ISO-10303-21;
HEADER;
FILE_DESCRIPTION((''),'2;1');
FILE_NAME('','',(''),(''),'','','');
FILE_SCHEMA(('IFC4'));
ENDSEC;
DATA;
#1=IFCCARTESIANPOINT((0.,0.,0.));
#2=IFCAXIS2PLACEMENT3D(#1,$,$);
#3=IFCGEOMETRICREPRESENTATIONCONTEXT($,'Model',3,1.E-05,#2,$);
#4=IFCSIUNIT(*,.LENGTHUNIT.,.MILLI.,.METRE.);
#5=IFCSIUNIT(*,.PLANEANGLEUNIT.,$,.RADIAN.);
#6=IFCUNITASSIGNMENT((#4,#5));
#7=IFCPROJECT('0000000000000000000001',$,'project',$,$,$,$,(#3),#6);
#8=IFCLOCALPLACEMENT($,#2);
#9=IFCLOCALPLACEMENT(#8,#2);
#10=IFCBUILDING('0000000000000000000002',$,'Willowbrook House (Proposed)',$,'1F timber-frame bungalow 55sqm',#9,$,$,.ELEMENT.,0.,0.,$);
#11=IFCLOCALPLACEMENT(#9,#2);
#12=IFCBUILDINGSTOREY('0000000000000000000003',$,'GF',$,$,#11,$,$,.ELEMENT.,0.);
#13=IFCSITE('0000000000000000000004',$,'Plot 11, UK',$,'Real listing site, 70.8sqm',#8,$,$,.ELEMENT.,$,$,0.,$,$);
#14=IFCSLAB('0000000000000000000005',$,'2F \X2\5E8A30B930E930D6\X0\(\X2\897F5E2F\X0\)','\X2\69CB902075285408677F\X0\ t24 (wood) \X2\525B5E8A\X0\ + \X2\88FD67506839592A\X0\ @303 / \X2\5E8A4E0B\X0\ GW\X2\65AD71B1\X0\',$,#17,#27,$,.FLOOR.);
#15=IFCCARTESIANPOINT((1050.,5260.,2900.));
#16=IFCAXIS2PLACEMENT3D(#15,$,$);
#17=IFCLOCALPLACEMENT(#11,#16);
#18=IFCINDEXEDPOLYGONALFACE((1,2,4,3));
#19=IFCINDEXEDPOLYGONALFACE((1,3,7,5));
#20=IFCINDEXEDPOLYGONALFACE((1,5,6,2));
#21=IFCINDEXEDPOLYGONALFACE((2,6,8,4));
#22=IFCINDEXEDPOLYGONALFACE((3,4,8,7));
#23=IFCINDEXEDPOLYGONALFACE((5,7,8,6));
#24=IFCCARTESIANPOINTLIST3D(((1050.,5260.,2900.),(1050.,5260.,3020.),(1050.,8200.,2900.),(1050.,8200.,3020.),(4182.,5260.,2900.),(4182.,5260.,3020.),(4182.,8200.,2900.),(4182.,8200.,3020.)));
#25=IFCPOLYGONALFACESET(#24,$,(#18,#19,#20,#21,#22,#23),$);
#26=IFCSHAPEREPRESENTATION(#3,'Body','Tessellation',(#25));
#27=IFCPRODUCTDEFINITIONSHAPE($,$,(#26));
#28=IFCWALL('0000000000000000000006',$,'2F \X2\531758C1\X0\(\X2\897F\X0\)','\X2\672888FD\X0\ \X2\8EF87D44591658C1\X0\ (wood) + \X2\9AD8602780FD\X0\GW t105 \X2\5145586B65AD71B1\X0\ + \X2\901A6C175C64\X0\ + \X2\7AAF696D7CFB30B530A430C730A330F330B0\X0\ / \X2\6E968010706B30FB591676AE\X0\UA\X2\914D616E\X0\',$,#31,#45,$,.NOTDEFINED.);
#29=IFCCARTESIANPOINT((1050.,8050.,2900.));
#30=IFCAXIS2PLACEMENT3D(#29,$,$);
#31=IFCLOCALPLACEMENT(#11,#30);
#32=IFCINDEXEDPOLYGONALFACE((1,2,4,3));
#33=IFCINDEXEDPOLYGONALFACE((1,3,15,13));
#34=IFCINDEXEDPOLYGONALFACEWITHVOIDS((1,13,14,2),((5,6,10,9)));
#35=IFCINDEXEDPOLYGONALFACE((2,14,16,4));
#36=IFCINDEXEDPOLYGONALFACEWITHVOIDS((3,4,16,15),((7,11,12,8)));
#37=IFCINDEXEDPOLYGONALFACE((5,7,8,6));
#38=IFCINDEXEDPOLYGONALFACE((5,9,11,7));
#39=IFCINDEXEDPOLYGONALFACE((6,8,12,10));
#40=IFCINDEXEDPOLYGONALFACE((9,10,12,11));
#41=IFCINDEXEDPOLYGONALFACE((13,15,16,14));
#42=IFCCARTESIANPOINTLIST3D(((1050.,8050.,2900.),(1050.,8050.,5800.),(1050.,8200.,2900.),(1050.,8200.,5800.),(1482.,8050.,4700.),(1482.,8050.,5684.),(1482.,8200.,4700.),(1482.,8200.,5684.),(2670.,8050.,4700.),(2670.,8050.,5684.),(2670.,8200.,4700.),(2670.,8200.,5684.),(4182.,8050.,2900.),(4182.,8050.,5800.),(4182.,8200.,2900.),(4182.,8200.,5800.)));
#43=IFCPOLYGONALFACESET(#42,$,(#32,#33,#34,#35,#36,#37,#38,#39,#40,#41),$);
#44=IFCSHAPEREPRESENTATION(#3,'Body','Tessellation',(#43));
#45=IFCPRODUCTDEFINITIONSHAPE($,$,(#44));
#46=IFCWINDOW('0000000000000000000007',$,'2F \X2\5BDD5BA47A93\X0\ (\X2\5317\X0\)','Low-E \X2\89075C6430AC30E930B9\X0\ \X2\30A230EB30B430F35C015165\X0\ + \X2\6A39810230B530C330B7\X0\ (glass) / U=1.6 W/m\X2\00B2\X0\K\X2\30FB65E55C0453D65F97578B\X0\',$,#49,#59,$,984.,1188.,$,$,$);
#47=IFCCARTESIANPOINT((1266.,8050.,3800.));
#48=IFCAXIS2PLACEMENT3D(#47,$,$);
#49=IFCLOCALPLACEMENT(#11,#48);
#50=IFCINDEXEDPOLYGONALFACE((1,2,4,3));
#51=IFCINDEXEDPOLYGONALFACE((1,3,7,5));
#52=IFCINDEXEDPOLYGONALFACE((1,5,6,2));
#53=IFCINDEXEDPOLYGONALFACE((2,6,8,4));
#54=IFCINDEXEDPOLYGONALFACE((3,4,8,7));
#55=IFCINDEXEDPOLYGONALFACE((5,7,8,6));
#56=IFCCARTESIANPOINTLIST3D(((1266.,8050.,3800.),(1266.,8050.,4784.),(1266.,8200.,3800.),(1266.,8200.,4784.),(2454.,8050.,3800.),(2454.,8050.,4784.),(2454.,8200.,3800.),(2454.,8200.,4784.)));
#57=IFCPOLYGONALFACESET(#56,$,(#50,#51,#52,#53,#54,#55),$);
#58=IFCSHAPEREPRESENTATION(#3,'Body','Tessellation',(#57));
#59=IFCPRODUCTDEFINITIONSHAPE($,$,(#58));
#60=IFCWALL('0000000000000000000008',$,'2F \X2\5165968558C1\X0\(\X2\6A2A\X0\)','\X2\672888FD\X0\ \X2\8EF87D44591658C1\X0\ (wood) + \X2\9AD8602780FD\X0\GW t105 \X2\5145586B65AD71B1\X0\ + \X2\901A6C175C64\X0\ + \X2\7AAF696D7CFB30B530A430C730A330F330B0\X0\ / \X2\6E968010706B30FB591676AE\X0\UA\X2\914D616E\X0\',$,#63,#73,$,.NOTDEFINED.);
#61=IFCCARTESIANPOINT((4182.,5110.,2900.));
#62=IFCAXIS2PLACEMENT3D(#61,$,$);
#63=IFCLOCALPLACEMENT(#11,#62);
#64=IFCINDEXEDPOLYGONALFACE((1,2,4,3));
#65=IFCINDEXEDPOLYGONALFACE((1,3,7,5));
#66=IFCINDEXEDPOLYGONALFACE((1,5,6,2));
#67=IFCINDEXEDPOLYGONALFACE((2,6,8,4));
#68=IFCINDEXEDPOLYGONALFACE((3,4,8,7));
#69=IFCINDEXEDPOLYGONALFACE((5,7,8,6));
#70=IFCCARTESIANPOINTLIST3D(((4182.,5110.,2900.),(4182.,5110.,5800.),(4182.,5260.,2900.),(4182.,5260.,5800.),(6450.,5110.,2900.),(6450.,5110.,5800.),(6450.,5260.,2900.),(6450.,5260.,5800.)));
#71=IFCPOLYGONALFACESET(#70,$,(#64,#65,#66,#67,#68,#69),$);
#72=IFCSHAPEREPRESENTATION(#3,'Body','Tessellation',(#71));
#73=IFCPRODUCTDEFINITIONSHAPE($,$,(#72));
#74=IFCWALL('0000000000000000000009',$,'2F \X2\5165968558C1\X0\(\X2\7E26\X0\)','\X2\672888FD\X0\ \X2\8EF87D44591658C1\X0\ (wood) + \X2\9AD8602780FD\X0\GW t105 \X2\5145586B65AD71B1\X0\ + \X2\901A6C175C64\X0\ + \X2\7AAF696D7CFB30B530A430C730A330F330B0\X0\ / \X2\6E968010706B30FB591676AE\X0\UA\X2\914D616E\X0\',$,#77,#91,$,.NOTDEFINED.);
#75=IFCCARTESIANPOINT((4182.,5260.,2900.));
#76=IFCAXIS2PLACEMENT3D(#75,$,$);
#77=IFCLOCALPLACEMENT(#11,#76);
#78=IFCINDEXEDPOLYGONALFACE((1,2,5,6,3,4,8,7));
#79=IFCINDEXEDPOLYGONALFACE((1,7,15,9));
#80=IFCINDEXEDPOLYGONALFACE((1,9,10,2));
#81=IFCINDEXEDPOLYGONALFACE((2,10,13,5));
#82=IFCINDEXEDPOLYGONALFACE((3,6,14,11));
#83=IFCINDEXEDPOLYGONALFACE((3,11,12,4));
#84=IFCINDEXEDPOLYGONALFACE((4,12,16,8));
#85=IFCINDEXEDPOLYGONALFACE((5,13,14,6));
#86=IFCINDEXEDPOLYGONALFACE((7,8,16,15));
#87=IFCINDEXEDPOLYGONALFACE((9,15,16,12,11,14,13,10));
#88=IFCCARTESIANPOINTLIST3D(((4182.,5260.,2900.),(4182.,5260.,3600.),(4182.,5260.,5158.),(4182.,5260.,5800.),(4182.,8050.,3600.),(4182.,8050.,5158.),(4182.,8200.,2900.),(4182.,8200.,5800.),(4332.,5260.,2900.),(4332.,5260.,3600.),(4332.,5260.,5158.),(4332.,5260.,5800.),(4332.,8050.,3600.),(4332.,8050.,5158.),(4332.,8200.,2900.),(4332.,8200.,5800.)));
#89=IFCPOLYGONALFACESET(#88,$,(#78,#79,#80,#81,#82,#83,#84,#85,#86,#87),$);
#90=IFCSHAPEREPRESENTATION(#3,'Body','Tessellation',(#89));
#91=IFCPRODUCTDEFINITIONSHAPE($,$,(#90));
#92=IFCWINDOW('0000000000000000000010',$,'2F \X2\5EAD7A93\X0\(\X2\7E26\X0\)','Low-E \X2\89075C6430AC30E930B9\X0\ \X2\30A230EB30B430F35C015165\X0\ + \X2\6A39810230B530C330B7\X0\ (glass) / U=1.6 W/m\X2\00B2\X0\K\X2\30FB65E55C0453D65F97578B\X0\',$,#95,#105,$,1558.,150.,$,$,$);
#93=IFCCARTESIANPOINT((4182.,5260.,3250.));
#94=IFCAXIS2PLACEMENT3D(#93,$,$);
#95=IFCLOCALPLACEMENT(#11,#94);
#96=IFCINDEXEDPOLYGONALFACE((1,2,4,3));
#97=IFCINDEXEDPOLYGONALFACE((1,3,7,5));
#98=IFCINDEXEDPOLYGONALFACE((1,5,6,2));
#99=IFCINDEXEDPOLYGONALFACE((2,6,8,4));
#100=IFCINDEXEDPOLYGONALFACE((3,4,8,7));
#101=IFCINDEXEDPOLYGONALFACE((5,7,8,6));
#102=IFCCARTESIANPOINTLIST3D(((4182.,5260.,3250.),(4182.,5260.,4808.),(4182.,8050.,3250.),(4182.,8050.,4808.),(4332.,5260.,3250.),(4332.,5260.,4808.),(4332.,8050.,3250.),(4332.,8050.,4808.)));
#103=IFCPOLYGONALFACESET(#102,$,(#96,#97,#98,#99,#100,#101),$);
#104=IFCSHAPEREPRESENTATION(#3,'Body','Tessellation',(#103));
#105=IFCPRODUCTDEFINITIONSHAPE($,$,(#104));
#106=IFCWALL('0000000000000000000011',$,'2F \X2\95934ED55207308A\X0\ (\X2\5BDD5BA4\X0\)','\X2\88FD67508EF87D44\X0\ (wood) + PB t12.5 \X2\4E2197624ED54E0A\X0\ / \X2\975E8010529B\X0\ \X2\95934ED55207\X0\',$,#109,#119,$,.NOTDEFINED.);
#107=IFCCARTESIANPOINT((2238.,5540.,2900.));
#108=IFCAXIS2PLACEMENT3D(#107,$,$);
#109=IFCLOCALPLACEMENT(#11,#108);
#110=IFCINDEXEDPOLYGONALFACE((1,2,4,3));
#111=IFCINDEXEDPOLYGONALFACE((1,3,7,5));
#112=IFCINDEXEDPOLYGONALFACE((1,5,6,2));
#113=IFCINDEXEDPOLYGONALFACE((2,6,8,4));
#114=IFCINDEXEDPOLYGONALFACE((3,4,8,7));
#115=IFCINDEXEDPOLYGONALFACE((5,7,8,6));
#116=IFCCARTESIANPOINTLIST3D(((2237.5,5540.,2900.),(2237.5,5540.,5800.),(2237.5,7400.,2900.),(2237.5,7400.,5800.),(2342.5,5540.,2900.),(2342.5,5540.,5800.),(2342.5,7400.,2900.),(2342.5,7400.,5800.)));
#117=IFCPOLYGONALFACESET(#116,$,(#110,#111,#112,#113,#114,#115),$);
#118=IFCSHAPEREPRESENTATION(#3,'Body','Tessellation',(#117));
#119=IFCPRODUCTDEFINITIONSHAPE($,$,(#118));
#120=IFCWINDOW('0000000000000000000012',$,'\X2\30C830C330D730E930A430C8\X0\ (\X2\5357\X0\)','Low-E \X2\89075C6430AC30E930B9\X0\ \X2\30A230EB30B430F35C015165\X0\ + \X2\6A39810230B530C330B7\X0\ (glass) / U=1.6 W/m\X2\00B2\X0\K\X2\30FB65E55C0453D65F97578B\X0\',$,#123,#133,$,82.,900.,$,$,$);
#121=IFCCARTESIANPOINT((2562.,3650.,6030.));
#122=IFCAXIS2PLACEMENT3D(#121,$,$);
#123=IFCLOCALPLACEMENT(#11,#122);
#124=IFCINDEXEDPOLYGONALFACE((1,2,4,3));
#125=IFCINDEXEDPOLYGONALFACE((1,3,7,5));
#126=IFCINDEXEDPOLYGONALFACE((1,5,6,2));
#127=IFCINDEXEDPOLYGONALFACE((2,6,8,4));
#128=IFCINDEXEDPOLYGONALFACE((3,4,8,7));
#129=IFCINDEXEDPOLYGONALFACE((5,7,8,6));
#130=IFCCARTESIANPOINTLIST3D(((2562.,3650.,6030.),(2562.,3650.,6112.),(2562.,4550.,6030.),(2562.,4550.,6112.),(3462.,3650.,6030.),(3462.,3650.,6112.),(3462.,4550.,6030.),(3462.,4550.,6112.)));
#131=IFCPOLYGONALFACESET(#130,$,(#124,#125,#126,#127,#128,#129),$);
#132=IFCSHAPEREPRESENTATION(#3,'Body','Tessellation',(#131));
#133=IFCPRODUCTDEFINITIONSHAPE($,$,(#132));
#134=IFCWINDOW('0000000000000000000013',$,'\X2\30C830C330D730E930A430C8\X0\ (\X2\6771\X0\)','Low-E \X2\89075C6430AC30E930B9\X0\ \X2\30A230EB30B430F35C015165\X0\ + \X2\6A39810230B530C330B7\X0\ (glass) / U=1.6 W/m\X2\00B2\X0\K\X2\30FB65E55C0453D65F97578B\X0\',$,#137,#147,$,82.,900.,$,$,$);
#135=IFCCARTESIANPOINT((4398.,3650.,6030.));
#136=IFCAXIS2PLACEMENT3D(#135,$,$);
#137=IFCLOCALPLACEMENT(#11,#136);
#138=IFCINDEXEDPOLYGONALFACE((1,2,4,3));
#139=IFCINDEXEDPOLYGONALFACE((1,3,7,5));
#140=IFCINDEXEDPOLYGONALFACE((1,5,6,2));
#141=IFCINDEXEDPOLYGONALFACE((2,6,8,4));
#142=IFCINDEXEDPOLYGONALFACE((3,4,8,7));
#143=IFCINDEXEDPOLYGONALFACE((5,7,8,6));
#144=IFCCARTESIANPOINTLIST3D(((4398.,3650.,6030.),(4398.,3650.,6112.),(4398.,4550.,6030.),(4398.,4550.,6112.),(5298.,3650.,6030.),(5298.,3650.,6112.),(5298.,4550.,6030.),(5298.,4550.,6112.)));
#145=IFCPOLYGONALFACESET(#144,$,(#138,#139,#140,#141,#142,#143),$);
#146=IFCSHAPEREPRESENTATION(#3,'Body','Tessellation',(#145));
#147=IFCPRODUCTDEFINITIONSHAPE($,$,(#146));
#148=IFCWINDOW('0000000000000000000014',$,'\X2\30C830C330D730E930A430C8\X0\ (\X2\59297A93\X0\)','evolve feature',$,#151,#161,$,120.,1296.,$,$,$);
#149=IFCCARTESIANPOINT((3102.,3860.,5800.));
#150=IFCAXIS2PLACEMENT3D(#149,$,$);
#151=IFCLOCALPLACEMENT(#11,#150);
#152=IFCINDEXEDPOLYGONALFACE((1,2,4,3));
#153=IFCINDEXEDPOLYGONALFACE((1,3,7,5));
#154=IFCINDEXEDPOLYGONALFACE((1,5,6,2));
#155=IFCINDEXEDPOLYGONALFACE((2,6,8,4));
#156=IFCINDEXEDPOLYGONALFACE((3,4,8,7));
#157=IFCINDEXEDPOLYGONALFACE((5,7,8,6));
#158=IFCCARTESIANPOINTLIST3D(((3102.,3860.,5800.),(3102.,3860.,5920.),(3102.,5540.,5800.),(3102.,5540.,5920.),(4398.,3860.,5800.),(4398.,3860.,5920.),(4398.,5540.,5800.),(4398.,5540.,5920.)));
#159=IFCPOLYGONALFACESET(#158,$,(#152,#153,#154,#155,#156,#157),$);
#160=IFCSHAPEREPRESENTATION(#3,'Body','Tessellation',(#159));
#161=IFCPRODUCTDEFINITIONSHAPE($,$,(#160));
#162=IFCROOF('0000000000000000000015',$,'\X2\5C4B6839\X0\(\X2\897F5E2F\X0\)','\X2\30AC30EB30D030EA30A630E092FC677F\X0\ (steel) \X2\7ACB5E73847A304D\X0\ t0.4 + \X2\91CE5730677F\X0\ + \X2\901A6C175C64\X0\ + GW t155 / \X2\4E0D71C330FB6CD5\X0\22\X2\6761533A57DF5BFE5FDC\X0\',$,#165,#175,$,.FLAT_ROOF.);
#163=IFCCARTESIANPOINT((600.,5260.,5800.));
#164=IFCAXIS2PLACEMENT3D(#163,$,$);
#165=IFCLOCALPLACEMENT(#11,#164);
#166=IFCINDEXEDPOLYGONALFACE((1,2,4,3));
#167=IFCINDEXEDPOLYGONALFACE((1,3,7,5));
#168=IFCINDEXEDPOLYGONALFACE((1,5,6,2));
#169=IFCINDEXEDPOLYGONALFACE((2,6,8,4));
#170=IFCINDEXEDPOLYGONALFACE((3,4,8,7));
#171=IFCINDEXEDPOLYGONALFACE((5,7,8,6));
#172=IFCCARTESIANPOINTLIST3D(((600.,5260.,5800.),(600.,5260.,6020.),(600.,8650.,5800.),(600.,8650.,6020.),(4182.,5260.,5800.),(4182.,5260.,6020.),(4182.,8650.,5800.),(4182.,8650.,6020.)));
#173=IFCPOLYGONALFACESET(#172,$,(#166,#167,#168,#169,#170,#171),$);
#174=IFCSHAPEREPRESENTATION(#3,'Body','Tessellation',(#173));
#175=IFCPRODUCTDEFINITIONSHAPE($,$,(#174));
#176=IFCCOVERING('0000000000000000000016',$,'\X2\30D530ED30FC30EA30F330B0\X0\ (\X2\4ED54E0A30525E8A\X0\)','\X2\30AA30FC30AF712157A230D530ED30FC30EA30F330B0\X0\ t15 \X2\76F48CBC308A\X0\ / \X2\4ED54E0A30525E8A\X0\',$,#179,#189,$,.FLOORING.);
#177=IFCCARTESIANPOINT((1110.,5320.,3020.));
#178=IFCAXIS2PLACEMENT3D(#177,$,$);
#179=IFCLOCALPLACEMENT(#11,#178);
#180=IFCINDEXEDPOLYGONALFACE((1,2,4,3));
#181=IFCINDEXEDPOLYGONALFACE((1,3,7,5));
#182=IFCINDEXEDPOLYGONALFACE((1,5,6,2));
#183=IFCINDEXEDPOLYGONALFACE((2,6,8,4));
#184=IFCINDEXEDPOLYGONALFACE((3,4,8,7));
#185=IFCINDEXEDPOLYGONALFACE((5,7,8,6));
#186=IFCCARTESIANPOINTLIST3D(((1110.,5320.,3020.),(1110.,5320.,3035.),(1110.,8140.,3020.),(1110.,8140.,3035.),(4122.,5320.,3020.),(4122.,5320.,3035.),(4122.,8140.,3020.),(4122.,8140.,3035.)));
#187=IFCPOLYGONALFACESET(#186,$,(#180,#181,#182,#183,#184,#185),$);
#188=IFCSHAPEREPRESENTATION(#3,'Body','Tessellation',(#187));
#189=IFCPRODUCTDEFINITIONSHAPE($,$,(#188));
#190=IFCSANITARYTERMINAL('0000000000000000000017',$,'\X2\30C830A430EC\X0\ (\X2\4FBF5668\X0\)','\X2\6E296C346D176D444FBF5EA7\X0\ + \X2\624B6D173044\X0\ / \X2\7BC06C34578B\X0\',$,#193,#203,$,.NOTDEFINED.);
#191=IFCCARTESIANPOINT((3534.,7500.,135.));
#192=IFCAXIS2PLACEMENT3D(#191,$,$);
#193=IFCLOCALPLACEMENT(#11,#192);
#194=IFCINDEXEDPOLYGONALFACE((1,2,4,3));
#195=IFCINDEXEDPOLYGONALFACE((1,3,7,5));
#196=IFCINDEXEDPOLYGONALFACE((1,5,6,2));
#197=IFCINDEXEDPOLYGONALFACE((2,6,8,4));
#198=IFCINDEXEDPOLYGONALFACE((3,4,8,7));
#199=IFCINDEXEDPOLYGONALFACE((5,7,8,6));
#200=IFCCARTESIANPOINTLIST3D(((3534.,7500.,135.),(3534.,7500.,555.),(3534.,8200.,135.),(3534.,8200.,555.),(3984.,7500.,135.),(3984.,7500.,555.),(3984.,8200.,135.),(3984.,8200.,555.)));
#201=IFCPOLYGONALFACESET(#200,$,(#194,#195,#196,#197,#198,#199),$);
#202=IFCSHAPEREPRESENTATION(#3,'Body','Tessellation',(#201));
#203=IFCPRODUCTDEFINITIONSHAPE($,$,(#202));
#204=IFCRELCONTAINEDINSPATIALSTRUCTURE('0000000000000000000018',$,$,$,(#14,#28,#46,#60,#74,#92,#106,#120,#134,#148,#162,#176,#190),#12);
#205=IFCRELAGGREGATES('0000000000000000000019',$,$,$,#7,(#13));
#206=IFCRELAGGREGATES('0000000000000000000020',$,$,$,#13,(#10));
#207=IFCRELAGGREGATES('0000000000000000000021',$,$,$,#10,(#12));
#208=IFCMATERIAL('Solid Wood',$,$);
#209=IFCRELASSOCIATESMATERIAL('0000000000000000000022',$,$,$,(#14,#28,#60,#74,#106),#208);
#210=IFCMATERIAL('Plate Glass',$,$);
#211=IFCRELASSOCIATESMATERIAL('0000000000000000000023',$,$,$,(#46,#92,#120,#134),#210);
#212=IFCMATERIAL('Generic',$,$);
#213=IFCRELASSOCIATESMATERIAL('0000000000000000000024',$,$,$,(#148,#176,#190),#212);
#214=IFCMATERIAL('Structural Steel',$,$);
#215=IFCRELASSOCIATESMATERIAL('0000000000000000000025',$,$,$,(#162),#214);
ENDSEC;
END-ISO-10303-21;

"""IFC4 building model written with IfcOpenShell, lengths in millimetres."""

from ifc_helpers import new_model, si_unit, frame, frame_2d, origin, place, context, project, spatial, rectangle, extrude, material, element, fill, save


model = new_model("IFC4")

# Units and contexts
model_context = context("Model", 3, precision=1e-05, world=origin())
ifc_project = project(units=[si_unit("LENGTHUNIT", "METRE", prefix="MILLI"), si_unit("PLANEANGLEUNIT", "RADIAN")], contexts=[model_context])

# Site, building, storey
site_placement = place(None, origin())
site = spatial("IfcSite", under=ifc_project, at=site_placement, Name="Plot 11, UK", ObjectType="Real listing site, 70.8sqm", CompositionType="ELEMENT", RefElevation=0.0)
building_placement = place(site_placement, origin())
building = spatial("IfcBuilding", under=site, at=building_placement, Name="Willowbrook House (Proposed)", ObjectType="1F timber-frame bungalow 55sqm", CompositionType="ELEMENT", ElevationOfRefHeight=0.0, ElevationOfTerrain=0.0)
storey_placement = place(building_placement, origin())
storey = spatial("IfcBuildingStorey", under=building, at=storey_placement, Name="GF", CompositionType="ELEMENT", Elevation=0.0)

# Slab
ifc_material_1 = material(Name="Solid Wood")
slab_placement = place(storey_placement, frame((1050.0, 5260.0, 2900.0)))
element("IfcSlab", 1, at=slab_placement, inside=storey, material=ifc_material_1, Name="2F 床スラブ(西帯)", Description="構造用合板 t24 (wood) 剛床 + 製材根太 @303 / 床下 GW断熱", PredefinedType="FLOOR", context=model_context, shape_type="SweptSolid", body=[
    extrude(rectangle(XDim=3132.0, YDim=2940.0, at=frame_2d((1566.0, 1470.0))), frame((1050.0, 5260.0, 2900.0)), (0.0, 0.0, 1.0), 120.0),
])

# Wall, opening, window
wall_1_placement = place(storey_placement, frame((1050.0, 8050.0, 2900.0)))
wall_1 = element("IfcWall", 2, at=wall_1_placement, inside=storey, material=ifc_material_1, Name="2F 北壁(西)", Description="木製 軸組外壁 (wood) + 高性能GW t105 充填断熱 + 通気層 + 窯業系サイディング / 準耐火・外皮UA配慮", PredefinedType="NOTDEFINED", context=model_context, shape_type="SweptSolid", body=[
    extrude(rectangle(XDim=3132.0, YDim=150.0, at=frame_2d((1566.0, 75.0))), frame((1050.0, 8050.0, 2900.0)), (0.0, 0.0, 1.0), 2900.0),
])
opening_1_placement = place(storey_placement, frame((1266.0, 8050.0, 3800.0)))
opening_1 = element("IfcOpeningElement", 3, at=opening_1_placement, cuts=wall_1, PredefinedType="NOTDEFINED", context=model_context, shape_type="SweptSolid", body=[
    extrude(rectangle(XDim=1188.0, YDim=150.0, at=frame_2d((594.0, 75.0))), frame((1266.0, 8050.0, 3800.0)), (0.0, 0.0, 1.0), 984.0),
])
ifc_material_2 = material(Name="Plate Glass")
window_1_placement = place(storey_placement, frame((1266.0, 8050.0, 3800.0)))
window_1 = element("IfcWindow", 4, at=window_1_placement, inside=storey, material=ifc_material_2, Name="2F 寝室窓 (北)", Description="Low-E 複層ガラス アルゴン封入 + 樹脂サッシ (glass) / U=1.6 W/m²K・日射取得型", OverallHeight=984.0, OverallWidth=1188.0, context=model_context, shape_type="SweptSolid", body=[
    extrude(rectangle(XDim=1188.0, YDim=150.0, at=frame_2d((594.0, 75.0))), frame((1266.0, 8050.0, 3800.0)), (0.0, 0.0, 1.0), 984.0),
])
fill(opening_1, window_1)

# Wall
wall_2_placement = place(storey_placement, frame((4182.0, 5110.0, 2900.0)))
element("IfcWall", 5, at=wall_2_placement, inside=storey, material=ifc_material_1, Name="2F 入隅壁(横)", Description="木製 軸組外壁 (wood) + 高性能GW t105 充填断熱 + 通気層 + 窯業系サイディング / 準耐火・外皮UA配慮", PredefinedType="NOTDEFINED", context=model_context, shape_type="SweptSolid", body=[
    extrude(rectangle(XDim=2268.0, YDim=150.0, at=frame_2d((1134.0, 75.0))), frame((4182.0, 5110.0, 2900.0)), (0.0, 0.0, 1.0), 2900.0),
])

# Wall, opening, window
wall_3_placement = place(storey_placement, frame((4182.0, 5260.0, 2900.0)))
wall_3 = element("IfcWall", 6, at=wall_3_placement, inside=storey, material=ifc_material_1, Name="2F 入隅壁(縦)", Description="木製 軸組外壁 (wood) + 高性能GW t105 充填断熱 + 通気層 + 窯業系サイディング / 準耐火・外皮UA配慮", PredefinedType="NOTDEFINED", context=model_context, shape_type="SweptSolid", body=[
    extrude(rectangle(XDim=150.0, YDim=2940.0, at=frame_2d((75.0, 1470.0))), frame((4182.0, 5260.0, 2900.0)), (0.0, 0.0, 1.0), 2900.0),
])
opening_2_placement = place(storey_placement, frame((4182.0, 5260.0, 3250.0)))
opening_2 = element("IfcOpeningElement", 7, at=opening_2_placement, cuts=wall_3, PredefinedType="NOTDEFINED", context=model_context, shape_type="SweptSolid", body=[
    extrude(rectangle(XDim=150.0, YDim=2790.0, at=frame_2d((75.0, 1395.0))), frame((4182.0, 5260.0, 3250.0)), (0.0, 0.0, 1.0), 1558.0),
])
window_2_placement = place(storey_placement, frame((4182.0, 5260.0, 3250.0)))
window_2 = element("IfcWindow", 8, at=window_2_placement, inside=storey, material=ifc_material_2, Name="2F 庭窓(縦)", Description="Low-E 複層ガラス アルゴン封入 + 樹脂サッシ (glass) / U=1.6 W/m²K・日射取得型", OverallHeight=1558.0, OverallWidth=150.0, context=model_context, shape_type="SweptSolid", body=[
    extrude(rectangle(XDim=150.0, YDim=2790.0, at=frame_2d((75.0, 1395.0))), frame((4182.0, 5260.0, 3250.0)), (0.0, 0.0, 1.0), 1558.0),
])
fill(opening_2, window_2)

# Wall
wall_4_placement = place(storey_placement, frame((2238.0, 5540.0, 2900.0)))
element("IfcWall", 9, at=wall_4_placement, inside=storey, material=ifc_material_1, Name="2F 間仕切り (寝室)", Description="製材軸組 (wood) + PB t12.5 両面仕上 / 非耐力 間仕切", PredefinedType="NOTDEFINED", context=model_context, shape_type="SweptSolid", body=[
    extrude(rectangle(XDim=105.0, YDim=1860.0, at=frame_2d((52.0, 930.0))), frame((2238.0, 5540.0, 2900.0)), (0.0, 0.0, 1.0), 2900.0),
])

# Windows
window_3_placement = place(storey_placement, frame((2562.0, 3650.0, 6030.0)))
element("IfcWindow", 10, at=window_3_placement, inside=storey, material=ifc_material_2, Name="トップライト (南)", Description="Low-E 複層ガラス アルゴン封入 + 樹脂サッシ (glass) / U=1.6 W/m²K・日射取得型", OverallHeight=82.0, OverallWidth=900.0, context=model_context, shape_type="SweptSolid", body=[
    extrude(rectangle(XDim=900.0, YDim=900.0, at=frame_2d((450.0, 450.0))), frame((2562.0, 3650.0, 6030.0)), (0.0, 0.0, 1.0), 82.0),
])
window_4_placement = place(storey_placement, frame((4398.0, 3650.0, 6030.0)))
element("IfcWindow", 11, at=window_4_placement, inside=storey, material=ifc_material_2, Name="トップライト (東)", Description="Low-E 複層ガラス アルゴン封入 + 樹脂サッシ (glass) / U=1.6 W/m²K・日射取得型", OverallHeight=82.0, OverallWidth=900.0, context=model_context, shape_type="SweptSolid", body=[
    extrude(rectangle(XDim=900.0, YDim=900.0, at=frame_2d((450.0, 450.0))), frame((4398.0, 3650.0, 6030.0)), (0.0, 0.0, 1.0), 82.0),
])
ifc_material_3 = material(Name="Generic")
window_5_placement = place(storey_placement, frame((3102.0, 3860.0, 5800.0)))
element("IfcWindow", 12, at=window_5_placement, inside=storey, material=ifc_material_3, Name="トップライト (天窓)", Description="evolve feature", OverallHeight=120.0, OverallWidth=1296.0, context=model_context, shape_type="SweptSolid", body=[
    extrude(rectangle(XDim=1296.0, YDim=1680.0, at=frame_2d((648.0, 840.0))), frame((3102.0, 3860.0, 5800.0)), (0.0, 0.0, 1.0), 120.0),
])

# Roof
ifc_material_4 = material(Name="Structural Steel")
for number, where, name in (
    (13, (600.0, 5260.0, 5800.0), "屋根(西帯)"),
):
    element("IfcRoof", number, at=place(storey_placement, frame(where)), inside=storey, material=ifc_material_4, Name=name, Description="ガルバリウム鋼板 (steel) 立平葺き t0.4 + 野地板 + 通気層 + GW t155 / 不燃・法22条区域対応", PredefinedType="FLAT_ROOF", context=model_context, shape_type="SweptSolid", body=[
        extrude(rectangle(XDim=3582.0, YDim=3390.0, at=frame_2d((1791.0, 1695.0))), frame((600.0, 5260.0, 5800.0)), (0.0, 0.0, 1.0), 220.0),
    ])

# Covering
covering_placement = place(storey_placement, frame((1110.0, 5320.0, 3020.0)))
element("IfcCovering", 14, at=covering_placement, inside=storey, material=ifc_material_3, Name="フローリング (仕上げ床)", Description="オーク無垢フローリング t15 直貼り / 仕上げ床", PredefinedType="FLOORING", context=model_context, shape_type="SweptSolid", body=[
    extrude(rectangle(XDim=3012.0, YDim=2820.0, at=frame_2d((1506.0, 1410.0))), frame((1110.0, 5320.0, 3020.0)), (0.0, 0.0, 1.0), 15.0),
])

# Sanitary terminal
sanitary_terminal_placement = place(storey_placement, frame((3534.0, 7500.0, 135.0)))
element("IfcSanitaryTerminal", 15, at=sanitary_terminal_placement, inside=storey, material=ifc_material_3, Name="トイレ (便器)", Description="温水洗浄便座 + 手洗い / 節水型", PredefinedType="NOTDEFINED", context=model_context, shape_type="SweptSolid", body=[
    extrude(rectangle(XDim=450.0, YDim=700.0, at=frame_2d((225.0, 350.0))), frame((3534.0, 7500.0, 135.0)), (0.0, 0.0, 1.0), 420.0),
])

save(model, "model.ifc")
